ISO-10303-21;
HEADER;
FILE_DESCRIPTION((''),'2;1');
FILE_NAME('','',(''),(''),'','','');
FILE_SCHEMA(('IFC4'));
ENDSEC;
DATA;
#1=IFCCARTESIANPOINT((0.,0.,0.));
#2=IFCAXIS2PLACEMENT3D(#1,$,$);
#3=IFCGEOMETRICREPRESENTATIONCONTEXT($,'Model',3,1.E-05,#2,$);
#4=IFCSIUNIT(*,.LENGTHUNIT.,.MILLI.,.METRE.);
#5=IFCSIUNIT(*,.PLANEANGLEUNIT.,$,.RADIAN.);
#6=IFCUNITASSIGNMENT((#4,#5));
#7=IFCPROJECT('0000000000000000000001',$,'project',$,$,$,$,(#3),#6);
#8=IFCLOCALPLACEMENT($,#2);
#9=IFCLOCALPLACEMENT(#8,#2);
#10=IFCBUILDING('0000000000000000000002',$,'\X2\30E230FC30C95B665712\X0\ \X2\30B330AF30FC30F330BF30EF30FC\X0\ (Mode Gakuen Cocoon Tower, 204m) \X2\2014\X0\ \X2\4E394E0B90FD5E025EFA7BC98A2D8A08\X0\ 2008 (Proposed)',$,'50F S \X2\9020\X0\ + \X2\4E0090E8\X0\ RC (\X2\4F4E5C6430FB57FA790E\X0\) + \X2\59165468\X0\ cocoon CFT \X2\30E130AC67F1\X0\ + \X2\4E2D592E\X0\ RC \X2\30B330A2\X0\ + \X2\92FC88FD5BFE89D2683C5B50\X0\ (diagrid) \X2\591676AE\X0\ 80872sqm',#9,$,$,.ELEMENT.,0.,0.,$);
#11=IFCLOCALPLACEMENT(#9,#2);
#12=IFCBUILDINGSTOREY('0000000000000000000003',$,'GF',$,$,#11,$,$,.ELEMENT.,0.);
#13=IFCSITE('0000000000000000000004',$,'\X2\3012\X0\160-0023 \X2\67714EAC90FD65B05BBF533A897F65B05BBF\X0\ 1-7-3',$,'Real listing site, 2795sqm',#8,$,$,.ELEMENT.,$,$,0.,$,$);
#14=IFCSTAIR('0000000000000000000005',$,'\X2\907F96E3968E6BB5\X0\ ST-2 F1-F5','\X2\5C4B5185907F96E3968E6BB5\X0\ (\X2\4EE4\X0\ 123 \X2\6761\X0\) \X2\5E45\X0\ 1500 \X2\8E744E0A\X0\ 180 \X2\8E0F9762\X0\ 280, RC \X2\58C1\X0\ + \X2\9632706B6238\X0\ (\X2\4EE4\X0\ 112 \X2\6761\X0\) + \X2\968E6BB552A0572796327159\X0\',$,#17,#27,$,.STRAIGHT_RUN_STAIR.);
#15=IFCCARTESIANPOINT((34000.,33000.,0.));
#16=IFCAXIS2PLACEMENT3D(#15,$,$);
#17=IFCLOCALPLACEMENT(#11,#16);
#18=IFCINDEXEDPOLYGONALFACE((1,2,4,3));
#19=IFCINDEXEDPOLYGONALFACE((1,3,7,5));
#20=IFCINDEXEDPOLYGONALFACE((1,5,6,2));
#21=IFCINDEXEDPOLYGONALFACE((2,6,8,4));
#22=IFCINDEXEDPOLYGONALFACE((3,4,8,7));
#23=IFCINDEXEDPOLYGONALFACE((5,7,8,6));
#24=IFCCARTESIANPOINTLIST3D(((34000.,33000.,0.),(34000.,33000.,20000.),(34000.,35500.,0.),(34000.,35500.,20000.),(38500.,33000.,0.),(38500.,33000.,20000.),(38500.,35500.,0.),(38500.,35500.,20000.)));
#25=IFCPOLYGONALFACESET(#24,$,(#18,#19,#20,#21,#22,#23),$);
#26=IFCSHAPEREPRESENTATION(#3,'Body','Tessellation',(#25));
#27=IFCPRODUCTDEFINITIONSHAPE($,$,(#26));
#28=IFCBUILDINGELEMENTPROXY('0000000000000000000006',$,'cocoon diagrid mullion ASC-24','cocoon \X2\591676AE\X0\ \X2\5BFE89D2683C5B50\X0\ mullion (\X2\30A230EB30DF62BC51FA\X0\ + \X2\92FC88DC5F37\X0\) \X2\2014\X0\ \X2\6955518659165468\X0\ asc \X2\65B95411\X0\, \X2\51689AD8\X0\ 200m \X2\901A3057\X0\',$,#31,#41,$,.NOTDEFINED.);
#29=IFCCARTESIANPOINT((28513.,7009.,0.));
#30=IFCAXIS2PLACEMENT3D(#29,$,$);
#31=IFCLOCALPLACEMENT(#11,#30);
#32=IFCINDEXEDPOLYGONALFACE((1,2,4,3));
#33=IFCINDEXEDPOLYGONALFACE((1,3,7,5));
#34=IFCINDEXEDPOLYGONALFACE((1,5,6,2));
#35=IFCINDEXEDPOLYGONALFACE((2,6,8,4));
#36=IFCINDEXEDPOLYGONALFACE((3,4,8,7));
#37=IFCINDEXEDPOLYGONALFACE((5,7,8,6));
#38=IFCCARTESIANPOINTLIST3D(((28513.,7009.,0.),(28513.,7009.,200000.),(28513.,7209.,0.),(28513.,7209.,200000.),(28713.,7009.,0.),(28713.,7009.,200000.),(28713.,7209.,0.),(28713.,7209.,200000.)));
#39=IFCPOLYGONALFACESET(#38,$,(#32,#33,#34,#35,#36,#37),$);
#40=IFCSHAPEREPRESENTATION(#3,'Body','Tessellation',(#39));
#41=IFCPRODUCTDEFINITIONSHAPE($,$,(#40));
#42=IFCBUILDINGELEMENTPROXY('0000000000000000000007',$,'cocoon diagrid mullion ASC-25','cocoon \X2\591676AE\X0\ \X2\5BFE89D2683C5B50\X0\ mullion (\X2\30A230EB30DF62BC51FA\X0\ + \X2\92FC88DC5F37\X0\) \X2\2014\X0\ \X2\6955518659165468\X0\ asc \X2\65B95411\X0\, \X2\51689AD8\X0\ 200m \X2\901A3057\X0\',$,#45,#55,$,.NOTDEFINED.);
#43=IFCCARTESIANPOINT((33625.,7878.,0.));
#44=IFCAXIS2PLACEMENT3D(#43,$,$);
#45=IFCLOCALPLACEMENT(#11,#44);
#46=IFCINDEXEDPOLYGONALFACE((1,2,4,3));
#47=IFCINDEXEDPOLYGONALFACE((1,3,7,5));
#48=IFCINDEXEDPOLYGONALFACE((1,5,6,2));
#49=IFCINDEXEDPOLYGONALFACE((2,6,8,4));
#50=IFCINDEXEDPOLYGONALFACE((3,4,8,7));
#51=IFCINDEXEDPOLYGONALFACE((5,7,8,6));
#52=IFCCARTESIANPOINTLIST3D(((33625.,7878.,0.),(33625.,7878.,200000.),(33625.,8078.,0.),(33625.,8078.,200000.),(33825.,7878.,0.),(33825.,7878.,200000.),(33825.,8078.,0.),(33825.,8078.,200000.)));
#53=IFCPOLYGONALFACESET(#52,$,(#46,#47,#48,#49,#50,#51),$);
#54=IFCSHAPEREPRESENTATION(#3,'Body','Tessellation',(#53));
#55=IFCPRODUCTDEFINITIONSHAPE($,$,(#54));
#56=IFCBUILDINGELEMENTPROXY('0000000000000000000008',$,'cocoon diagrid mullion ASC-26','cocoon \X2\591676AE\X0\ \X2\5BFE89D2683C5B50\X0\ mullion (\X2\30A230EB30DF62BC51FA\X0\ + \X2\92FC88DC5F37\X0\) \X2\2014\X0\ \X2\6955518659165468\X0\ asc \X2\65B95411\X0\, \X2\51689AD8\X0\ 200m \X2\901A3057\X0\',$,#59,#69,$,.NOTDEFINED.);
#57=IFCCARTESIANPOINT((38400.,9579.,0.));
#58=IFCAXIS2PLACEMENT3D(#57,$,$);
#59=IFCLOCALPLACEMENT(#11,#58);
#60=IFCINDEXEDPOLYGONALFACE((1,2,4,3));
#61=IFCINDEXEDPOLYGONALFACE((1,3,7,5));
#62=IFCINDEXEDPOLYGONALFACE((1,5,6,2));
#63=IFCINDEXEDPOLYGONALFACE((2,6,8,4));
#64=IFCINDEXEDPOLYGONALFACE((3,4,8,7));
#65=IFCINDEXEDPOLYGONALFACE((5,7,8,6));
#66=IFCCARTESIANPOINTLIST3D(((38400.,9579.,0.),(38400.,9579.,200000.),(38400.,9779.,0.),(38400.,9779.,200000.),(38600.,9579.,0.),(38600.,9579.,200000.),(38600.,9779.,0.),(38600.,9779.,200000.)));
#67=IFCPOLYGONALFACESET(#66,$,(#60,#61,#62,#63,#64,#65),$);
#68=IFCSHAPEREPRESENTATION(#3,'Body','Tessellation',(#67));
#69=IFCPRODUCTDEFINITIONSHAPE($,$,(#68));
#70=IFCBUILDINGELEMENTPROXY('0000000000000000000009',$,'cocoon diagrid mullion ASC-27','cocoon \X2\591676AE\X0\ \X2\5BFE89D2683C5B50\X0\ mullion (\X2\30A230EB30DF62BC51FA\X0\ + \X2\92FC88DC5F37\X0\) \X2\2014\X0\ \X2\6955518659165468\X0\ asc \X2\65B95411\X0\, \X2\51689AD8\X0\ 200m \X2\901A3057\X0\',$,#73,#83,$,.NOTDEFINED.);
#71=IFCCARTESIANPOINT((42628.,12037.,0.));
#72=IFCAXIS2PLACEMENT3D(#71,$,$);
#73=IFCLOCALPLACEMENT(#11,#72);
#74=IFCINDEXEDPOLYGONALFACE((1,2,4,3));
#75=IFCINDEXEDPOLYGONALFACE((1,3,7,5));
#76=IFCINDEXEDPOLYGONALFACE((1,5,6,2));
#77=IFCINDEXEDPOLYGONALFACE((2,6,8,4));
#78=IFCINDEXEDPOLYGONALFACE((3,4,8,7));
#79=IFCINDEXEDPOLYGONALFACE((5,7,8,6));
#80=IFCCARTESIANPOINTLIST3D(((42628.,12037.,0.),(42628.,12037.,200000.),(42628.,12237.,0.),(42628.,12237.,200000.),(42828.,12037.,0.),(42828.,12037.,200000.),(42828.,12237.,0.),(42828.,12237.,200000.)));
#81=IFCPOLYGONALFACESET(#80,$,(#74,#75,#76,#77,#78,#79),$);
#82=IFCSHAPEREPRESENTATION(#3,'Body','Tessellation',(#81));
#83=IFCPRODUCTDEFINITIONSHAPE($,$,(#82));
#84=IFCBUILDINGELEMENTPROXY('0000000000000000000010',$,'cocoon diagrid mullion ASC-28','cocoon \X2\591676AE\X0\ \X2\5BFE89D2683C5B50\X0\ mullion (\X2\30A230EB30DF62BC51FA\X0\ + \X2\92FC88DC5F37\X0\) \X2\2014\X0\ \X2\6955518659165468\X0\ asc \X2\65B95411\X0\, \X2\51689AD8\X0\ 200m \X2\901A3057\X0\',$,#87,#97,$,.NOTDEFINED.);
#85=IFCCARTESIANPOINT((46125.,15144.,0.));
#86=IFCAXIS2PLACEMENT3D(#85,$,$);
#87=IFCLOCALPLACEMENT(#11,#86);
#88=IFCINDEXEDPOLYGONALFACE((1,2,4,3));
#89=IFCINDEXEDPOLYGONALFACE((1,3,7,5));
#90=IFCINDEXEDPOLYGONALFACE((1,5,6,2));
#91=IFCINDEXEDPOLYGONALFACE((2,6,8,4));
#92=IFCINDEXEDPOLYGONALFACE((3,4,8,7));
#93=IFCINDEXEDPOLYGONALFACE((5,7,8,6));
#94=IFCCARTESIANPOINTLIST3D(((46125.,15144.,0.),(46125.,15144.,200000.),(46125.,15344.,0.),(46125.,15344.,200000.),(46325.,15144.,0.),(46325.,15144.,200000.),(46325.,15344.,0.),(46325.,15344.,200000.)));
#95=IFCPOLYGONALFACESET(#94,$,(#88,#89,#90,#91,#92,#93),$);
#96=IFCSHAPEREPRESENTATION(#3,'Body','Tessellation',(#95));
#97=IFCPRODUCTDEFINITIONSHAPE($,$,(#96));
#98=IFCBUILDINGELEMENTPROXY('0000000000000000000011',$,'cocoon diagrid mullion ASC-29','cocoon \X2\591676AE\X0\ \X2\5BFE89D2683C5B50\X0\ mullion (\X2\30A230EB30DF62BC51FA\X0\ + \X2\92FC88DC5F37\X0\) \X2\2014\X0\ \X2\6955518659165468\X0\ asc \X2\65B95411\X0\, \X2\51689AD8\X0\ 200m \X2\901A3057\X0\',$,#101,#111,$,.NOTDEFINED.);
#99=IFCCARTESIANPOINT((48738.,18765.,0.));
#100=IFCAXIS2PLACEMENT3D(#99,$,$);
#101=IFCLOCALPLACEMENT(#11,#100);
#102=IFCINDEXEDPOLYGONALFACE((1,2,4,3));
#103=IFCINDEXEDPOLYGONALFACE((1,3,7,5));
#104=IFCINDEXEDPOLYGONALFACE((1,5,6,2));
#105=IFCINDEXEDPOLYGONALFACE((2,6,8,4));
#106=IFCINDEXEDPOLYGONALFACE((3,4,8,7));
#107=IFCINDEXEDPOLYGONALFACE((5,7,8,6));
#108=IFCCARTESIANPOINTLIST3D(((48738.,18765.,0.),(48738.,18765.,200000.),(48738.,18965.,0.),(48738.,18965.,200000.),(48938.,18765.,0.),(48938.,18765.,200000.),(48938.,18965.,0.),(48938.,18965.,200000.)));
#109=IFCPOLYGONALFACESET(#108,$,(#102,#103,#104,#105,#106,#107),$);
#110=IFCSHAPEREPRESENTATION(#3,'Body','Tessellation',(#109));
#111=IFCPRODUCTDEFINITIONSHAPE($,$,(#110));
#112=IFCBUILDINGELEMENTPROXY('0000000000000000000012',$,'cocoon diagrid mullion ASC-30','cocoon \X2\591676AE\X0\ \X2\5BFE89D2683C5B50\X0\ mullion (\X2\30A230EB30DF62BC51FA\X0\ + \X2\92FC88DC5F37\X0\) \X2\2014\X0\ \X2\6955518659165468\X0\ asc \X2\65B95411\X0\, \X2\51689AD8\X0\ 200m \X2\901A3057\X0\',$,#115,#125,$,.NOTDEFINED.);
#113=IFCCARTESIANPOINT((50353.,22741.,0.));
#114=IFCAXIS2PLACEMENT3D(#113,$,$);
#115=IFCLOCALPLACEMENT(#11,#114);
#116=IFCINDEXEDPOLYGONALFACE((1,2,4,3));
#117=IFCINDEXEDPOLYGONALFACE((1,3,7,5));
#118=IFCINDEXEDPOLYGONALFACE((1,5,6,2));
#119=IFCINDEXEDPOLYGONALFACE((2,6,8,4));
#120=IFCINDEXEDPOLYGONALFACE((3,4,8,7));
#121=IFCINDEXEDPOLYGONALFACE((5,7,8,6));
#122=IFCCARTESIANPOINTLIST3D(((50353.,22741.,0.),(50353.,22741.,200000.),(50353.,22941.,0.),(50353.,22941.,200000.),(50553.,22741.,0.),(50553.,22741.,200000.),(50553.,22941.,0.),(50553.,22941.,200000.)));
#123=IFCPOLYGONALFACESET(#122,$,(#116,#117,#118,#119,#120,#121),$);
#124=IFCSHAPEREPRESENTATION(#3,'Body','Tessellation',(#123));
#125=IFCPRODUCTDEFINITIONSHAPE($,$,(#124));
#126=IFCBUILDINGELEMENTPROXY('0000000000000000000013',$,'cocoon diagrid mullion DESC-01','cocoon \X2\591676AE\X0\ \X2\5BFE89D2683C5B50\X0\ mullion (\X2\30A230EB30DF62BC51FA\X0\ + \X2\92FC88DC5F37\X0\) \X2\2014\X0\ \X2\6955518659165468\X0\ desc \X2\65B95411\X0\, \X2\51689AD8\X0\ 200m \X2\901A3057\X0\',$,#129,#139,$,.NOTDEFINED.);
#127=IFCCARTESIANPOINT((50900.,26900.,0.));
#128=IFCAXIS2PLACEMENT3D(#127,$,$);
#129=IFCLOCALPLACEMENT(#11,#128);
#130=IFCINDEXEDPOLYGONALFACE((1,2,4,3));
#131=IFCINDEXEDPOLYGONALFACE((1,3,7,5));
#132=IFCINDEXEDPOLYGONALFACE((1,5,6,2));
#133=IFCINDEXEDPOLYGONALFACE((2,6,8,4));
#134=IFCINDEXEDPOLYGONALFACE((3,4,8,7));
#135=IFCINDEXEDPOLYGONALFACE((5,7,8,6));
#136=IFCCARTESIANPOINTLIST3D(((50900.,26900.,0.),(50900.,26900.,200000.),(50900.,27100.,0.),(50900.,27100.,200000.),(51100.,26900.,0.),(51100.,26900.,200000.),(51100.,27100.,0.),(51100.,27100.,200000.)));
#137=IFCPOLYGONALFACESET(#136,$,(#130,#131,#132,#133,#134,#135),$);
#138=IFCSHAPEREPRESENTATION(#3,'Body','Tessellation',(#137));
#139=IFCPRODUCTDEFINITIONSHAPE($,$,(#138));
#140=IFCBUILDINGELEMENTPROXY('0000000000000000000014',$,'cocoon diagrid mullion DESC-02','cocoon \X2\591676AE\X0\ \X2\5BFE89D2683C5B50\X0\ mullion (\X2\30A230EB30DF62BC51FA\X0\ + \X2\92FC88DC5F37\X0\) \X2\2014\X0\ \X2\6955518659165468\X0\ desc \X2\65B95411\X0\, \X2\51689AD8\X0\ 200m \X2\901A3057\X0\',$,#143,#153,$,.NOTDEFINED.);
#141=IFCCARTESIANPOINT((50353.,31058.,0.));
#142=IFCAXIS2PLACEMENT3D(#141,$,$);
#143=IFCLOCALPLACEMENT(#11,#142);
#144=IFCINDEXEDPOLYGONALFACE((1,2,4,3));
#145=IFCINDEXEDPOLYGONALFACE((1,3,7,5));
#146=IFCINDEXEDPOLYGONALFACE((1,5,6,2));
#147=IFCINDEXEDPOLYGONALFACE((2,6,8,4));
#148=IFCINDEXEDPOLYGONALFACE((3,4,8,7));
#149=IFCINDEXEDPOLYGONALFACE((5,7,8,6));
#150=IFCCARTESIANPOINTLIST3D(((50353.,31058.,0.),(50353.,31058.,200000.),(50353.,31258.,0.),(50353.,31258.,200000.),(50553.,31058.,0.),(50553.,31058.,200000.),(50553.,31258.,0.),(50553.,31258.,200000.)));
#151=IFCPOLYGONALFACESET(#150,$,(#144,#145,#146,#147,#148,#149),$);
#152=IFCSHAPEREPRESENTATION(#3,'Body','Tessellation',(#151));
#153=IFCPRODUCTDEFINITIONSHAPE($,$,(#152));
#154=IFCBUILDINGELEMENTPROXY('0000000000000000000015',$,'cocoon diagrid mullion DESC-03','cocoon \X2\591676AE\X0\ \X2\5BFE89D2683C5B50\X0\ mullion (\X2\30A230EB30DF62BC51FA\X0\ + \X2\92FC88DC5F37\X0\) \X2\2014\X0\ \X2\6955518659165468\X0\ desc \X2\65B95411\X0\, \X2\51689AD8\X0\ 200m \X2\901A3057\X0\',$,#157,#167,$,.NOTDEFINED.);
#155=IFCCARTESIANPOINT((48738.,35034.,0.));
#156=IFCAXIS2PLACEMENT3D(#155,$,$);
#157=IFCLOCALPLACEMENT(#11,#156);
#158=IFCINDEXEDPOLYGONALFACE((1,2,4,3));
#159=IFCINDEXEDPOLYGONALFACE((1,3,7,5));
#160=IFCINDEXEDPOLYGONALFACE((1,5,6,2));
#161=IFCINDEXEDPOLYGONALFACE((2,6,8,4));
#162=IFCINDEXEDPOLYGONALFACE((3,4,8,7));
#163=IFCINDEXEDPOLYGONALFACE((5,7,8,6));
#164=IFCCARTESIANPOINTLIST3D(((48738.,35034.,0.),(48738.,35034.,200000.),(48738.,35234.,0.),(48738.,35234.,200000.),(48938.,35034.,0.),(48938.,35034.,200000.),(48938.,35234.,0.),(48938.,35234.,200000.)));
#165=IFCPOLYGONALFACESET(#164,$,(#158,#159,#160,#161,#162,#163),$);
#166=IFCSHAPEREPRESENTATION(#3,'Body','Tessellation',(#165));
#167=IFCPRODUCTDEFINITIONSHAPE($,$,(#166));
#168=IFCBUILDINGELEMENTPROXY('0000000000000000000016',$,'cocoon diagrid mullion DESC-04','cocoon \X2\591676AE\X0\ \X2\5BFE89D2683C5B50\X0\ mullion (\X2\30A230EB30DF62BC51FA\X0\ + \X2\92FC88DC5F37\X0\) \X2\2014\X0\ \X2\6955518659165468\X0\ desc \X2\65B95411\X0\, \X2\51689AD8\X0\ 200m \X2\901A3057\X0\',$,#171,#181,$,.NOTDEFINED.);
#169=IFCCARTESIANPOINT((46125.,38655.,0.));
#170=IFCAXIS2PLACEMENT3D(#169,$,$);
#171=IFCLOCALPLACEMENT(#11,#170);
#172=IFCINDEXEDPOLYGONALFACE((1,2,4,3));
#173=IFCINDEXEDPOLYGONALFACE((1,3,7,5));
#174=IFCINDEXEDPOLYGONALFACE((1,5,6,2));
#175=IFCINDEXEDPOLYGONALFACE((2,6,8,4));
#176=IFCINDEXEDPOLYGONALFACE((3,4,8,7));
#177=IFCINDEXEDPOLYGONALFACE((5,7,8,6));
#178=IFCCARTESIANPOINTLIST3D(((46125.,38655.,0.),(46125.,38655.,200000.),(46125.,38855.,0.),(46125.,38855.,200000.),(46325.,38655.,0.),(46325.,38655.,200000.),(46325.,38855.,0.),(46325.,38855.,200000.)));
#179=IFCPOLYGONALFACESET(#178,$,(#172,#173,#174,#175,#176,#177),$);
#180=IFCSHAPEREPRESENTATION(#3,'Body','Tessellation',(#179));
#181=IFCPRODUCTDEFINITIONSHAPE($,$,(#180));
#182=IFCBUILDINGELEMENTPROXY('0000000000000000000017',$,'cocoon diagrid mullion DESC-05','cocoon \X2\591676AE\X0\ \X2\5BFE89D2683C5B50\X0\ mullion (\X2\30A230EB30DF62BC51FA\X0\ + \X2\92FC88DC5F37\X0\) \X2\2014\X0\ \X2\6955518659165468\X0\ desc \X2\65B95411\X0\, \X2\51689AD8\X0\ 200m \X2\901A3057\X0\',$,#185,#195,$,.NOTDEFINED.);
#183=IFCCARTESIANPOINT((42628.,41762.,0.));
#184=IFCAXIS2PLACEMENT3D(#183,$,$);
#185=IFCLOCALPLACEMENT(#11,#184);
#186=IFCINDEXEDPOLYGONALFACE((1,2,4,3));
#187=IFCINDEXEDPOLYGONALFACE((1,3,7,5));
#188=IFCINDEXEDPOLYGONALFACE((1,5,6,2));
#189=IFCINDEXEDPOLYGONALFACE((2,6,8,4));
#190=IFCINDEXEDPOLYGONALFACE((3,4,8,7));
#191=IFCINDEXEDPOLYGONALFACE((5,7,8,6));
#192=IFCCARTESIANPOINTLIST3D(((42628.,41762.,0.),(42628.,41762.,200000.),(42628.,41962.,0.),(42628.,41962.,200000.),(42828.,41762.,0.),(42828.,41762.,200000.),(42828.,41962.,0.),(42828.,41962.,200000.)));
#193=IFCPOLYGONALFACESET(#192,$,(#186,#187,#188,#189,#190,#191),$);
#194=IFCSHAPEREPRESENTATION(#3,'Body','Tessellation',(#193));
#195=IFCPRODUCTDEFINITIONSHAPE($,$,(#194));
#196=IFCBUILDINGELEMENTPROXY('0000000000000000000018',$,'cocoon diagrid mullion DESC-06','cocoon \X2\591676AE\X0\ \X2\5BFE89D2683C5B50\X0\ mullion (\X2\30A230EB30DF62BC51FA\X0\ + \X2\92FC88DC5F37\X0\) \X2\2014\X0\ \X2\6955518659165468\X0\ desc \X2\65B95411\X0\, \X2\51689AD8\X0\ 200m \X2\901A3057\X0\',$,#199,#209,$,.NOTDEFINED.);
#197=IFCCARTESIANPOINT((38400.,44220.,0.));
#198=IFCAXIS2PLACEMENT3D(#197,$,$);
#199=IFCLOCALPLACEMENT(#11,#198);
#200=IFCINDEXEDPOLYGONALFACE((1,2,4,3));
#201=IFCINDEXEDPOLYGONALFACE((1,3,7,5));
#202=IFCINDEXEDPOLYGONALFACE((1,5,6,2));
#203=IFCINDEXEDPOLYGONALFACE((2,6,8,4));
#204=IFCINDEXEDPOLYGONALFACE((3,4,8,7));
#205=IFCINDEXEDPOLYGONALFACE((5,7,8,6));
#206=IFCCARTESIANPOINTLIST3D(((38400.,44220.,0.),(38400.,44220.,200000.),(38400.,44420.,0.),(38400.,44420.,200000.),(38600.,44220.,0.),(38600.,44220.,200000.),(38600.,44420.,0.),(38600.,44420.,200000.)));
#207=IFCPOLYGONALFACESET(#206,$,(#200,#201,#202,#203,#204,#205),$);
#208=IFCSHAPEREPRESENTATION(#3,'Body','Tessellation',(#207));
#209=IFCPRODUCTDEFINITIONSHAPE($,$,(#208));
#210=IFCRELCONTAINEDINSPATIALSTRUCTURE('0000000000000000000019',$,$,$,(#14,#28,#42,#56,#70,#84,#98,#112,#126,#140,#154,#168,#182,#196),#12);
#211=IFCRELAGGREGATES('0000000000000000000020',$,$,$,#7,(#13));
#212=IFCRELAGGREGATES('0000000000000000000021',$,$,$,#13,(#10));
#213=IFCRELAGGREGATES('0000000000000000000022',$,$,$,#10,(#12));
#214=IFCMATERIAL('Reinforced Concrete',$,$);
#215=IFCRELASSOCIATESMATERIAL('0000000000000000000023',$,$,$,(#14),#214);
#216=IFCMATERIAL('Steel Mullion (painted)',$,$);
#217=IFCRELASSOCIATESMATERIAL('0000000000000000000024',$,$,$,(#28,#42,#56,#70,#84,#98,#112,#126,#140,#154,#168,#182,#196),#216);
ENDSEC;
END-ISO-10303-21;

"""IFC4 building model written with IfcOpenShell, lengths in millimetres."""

from ifc_helpers import new_model, si_unit, frame, frame_2d, origin, place, context, project, spatial, rectangle, extrude, material, element, save


model = new_model("IFC4")

# Units and contexts
model_context = context("Model", 3, precision=1e-05, world=origin())
ifc_project = project(units=[si_unit("LENGTHUNIT", "METRE", prefix="MILLI"), si_unit("PLANEANGLEUNIT", "RADIAN")], contexts=[model_context])

# Site, building, storey
site_placement = place(None, origin())
site = spatial("IfcSite", under=ifc_project, at=site_placement, Name="〒160-0023 東京都新宿区西新宿 1-7-3", ObjectType="Real listing site, 2795sqm", CompositionType="ELEMENT", RefElevation=0.0)
building_placement = place(site_placement, origin())
building = spatial("IfcBuilding", under=site, at=building_placement, Name="モード学園 コクーンタワー (Mode Gakuen Cocoon Tower, 204m) — 丹下都市建築設計 2008 (Proposed)", ObjectType="50F S 造 + 一部 RC (低層・基礎) + 外周 cocoon CFT メガ柱 + 中央 RC コア + 鋼製対角格子 (diagrid) 外皮 80872sqm", CompositionType="ELEMENT", ElevationOfRefHeight=0.0, ElevationOfTerrain=0.0)
storey_placement = place(building_placement, origin())
storey = spatial("IfcBuildingStorey", under=building, at=storey_placement, Name="GF", CompositionType="ELEMENT", Elevation=0.0)

# Stair
ifc_material_1 = material(Name="Reinforced Concrete")
stair_placement = place(storey_placement, frame((34000.0, 33000.0, 0.0)))
element("IfcStair", 1, at=stair_placement, inside=storey, material=ifc_material_1, Name="避難階段 ST-2 F1-F5", Description="屋内避難階段 (令 123 条) 幅 1500 蹴上 180 踏面 280, RC 壁 + 防火戸 (令 112 条) + 階段加圧防煙", PredefinedType="STRAIGHT_RUN_STAIR", context=model_context, shape_type="SweptSolid", body=[
    extrude(rectangle(XDim=4500.0, YDim=2500.0, at=frame_2d((2250.0, 1250.0))), frame((34000.0, 33000.0, 0.0)), (0.0, 0.0, 1.0), 20000.0),
])

# Building element proxies
ifc_material_2 = material(Name="Steel Mullion (painted)")
proxy_1_placement = place(storey_placement, frame((28513.0, 7009.0, 0.0)))
element("IfcBuildingElementProxy", 2, at=proxy_1_placement, inside=storey, material=ifc_material_2, Name="cocoon diagrid mullion ASC-24", Description="cocoon 外皮 対角格子 mullion (アルミ押出 + 鋼補強) — 楕円外周 asc 方向, 全高 200m 通し", PredefinedType="NOTDEFINED", context=model_context, shape_type="SweptSolid", body=[
    extrude(rectangle(XDim=200.0, YDim=200.0, at=frame_2d((100.0, 100.0))), frame((28513.0, 7009.0, 0.0)), (0.0, 0.0, 1.0), 200000.0),
])
proxy_2_placement = place(storey_placement, frame((33625.0, 7878.0, 0.0)))
element("IfcBuildingElementProxy", 3, at=proxy_2_placement, inside=storey, material=ifc_material_2, Name="cocoon diagrid mullion ASC-25", Description="cocoon 外皮 対角格子 mullion (アルミ押出 + 鋼補強) — 楕円外周 asc 方向, 全高 200m 通し", PredefinedType="NOTDEFINED", context=model_context, shape_type="SweptSolid", body=[
    extrude(rectangle(XDim=200.0, YDim=200.0, at=frame_2d((100.0, 100.0))), frame((33625.0, 7878.0, 0.0)), (0.0, 0.0, 1.0), 200000.0),
])
proxy_3_placement = place(storey_placement, frame((38400.0, 9579.0, 0.0)))
element("IfcBuildingElementProxy", 4, at=proxy_3_placement, inside=storey, material=ifc_material_2, Name="cocoon diagrid mullion ASC-26", Description="cocoon 外皮 対角格子 mullion (アルミ押出 + 鋼補強) — 楕円外周 asc 方向, 全高 200m 通し", PredefinedType="NOTDEFINED", context=model_context, shape_type="SweptSolid", body=[
    extrude(rectangle(XDim=200.0, YDim=200.0, at=frame_2d((100.0, 100.0))), frame((38400.0, 9579.0, 0.0)), (0.0, 0.0, 1.0), 200000.0),
])
proxy_4_placement = place(storey_placement, frame((42628.0, 12037.0, 0.0)))
element("IfcBuildingElementProxy", 5, at=proxy_4_placement, inside=storey, material=ifc_material_2, Name="cocoon diagrid mullion ASC-27", Description="cocoon 外皮 対角格子 mullion (アルミ押出 + 鋼補強) — 楕円外周 asc 方向, 全高 200m 通し", PredefinedType="NOTDEFINED", context=model_context, shape_type="SweptSolid", body=[
    extrude(rectangle(XDim=200.0, YDim=200.0, at=frame_2d((100.0, 100.0))), frame((42628.0, 12037.0, 0.0)), (0.0, 0.0, 1.0), 200000.0),
])
proxy_5_placement = place(storey_placement, frame((46125.0, 15144.0, 0.0)))
element("IfcBuildingElementProxy", 6, at=proxy_5_placement, inside=storey, material=ifc_material_2, Name="cocoon diagrid mullion ASC-28", Description="cocoon 外皮 対角格子 mullion (アルミ押出 + 鋼補強) — 楕円外周 asc 方向, 全高 200m 通し", PredefinedType="NOTDEFINED", context=model_context, shape_type="SweptSolid", body=[
    extrude(rectangle(XDim=200.0, YDim=200.0, at=frame_2d((100.0, 100.0))), frame((46125.0, 15144.0, 0.0)), (0.0, 0.0, 1.0), 200000.0),
])
proxy_6_placement = place(storey_placement, frame((48738.0, 18765.0, 0.0)))
element("IfcBuildingElementProxy", 7, at=proxy_6_placement, inside=storey, material=ifc_material_2, Name="cocoon diagrid mullion ASC-29", Description="cocoon 外皮 対角格子 mullion (アルミ押出 + 鋼補強) — 楕円外周 asc 方向, 全高 200m 通し", PredefinedType="NOTDEFINED", context=model_context, shape_type="SweptSolid", body=[
    extrude(rectangle(XDim=200.0, YDim=200.0, at=frame_2d((100.0, 100.0))), frame((48738.0, 18765.0, 0.0)), (0.0, 0.0, 1.0), 200000.0),
])
proxy_7_placement = place(storey_placement, frame((50353.0, 22741.0, 0.0)))
element("IfcBuildingElementProxy", 8, at=proxy_7_placement, inside=storey, material=ifc_material_2, Name="cocoon diagrid mullion ASC-30", Description="cocoon 外皮 対角格子 mullion (アルミ押出 + 鋼補強) — 楕円外周 asc 方向, 全高 200m 通し", PredefinedType="NOTDEFINED", context=model_context, shape_type="SweptSolid", body=[
    extrude(rectangle(XDim=200.0, YDim=200.0, at=frame_2d((100.0, 100.0))), frame((50353.0, 22741.0, 0.0)), (0.0, 0.0, 1.0), 200000.0),
])
proxy_8_placement = place(storey_placement, frame((50900.0, 26900.0, 0.0)))
element("IfcBuildingElementProxy", 9, at=proxy_8_placement, inside=storey, material=ifc_material_2, Name="cocoon diagrid mullion DESC-01", Description="cocoon 外皮 対角格子 mullion (アルミ押出 + 鋼補強) — 楕円外周 desc 方向, 全高 200m 通し", PredefinedType="NOTDEFINED", context=model_context, shape_type="SweptSolid", body=[
    extrude(rectangle(XDim=200.0, YDim=200.0, at=frame_2d((100.0, 100.0))), frame((50900.0, 26900.0, 0.0)), (0.0, 0.0, 1.0), 200000.0),
])
proxy_9_placement = place(storey_placement, frame((50353.0, 31058.0, 0.0)))
element("IfcBuildingElementProxy", 10, at=proxy_9_placement, inside=storey, material=ifc_material_2, Name="cocoon diagrid mullion DESC-02", Description="cocoon 外皮 対角格子 mullion (アルミ押出 + 鋼補強) — 楕円外周 desc 方向, 全高 200m 通し", PredefinedType="NOTDEFINED", context=model_context, shape_type="SweptSolid", body=[
    extrude(rectangle(XDim=200.0, YDim=200.0, at=frame_2d((100.0, 100.0))), frame((50353.0, 31058.0, 0.0)), (0.0, 0.0, 1.0), 200000.0),
])
proxy_10_placement = place(storey_placement, frame((48738.0, 35034.0, 0.0)))
element("IfcBuildingElementProxy", 11, at=proxy_10_placement, inside=storey, material=ifc_material_2, Name="cocoon diagrid mullion DESC-03", Description="cocoon 外皮 対角格子 mullion (アルミ押出 + 鋼補強) — 楕円外周 desc 方向, 全高 200m 通し", PredefinedType="NOTDEFINED", context=model_context, shape_type="SweptSolid", body=[
    extrude(rectangle(XDim=200.0, YDim=200.0, at=frame_2d((100.0, 100.0))), frame((48738.0, 35034.0, 0.0)), (0.0, 0.0, 1.0), 200000.0),
])
proxy_11_placement = place(storey_placement, frame((46125.0, 38655.0, 0.0)))
element("IfcBuildingElementProxy", 12, at=proxy_11_placement, inside=storey, material=ifc_material_2, Name="cocoon diagrid mullion DESC-04", Description="cocoon 外皮 対角格子 mullion (アルミ押出 + 鋼補強) — 楕円外周 desc 方向, 全高 200m 通し", PredefinedType="NOTDEFINED", context=model_context, shape_type="SweptSolid", body=[
    extrude(rectangle(XDim=200.0, YDim=200.0, at=frame_2d((100.0, 100.0))), frame((46125.0, 38655.0, 0.0)), (0.0, 0.0, 1.0), 200000.0),
])
proxy_12_placement = place(storey_placement, frame((42628.0, 41762.0, 0.0)))
element("IfcBuildingElementProxy", 13, at=proxy_12_placement, inside=storey, material=ifc_material_2, Name="cocoon diagrid mullion DESC-05", Description="cocoon 外皮 対角格子 mullion (アルミ押出 + 鋼補強) — 楕円外周 desc 方向, 全高 200m 通し", PredefinedType="NOTDEFINED", context=model_context, shape_type="SweptSolid", body=[
    extrude(rectangle(XDim=200.0, YDim=200.0, at=frame_2d((100.0, 100.0))), frame((42628.0, 41762.0, 0.0)), (0.0, 0.0, 1.0), 200000.0),
])
proxy_13_placement = place(storey_placement, frame((38400.0, 44220.0, 0.0)))
element("IfcBuildingElementProxy", 14, at=proxy_13_placement, inside=storey, material=ifc_material_2, Name="cocoon diagrid mullion DESC-06", Description="cocoon 外皮 対角格子 mullion (アルミ押出 + 鋼補強) — 楕円外周 desc 方向, 全高 200m 通し", PredefinedType="NOTDEFINED", context=model_context, shape_type="SweptSolid", body=[
    extrude(rectangle(XDim=200.0, YDim=200.0, at=frame_2d((100.0, 100.0))), frame((38400.0, 44220.0, 0.0)), (0.0, 0.0, 1.0), 200000.0),
])

save(model, "model.ifc")
